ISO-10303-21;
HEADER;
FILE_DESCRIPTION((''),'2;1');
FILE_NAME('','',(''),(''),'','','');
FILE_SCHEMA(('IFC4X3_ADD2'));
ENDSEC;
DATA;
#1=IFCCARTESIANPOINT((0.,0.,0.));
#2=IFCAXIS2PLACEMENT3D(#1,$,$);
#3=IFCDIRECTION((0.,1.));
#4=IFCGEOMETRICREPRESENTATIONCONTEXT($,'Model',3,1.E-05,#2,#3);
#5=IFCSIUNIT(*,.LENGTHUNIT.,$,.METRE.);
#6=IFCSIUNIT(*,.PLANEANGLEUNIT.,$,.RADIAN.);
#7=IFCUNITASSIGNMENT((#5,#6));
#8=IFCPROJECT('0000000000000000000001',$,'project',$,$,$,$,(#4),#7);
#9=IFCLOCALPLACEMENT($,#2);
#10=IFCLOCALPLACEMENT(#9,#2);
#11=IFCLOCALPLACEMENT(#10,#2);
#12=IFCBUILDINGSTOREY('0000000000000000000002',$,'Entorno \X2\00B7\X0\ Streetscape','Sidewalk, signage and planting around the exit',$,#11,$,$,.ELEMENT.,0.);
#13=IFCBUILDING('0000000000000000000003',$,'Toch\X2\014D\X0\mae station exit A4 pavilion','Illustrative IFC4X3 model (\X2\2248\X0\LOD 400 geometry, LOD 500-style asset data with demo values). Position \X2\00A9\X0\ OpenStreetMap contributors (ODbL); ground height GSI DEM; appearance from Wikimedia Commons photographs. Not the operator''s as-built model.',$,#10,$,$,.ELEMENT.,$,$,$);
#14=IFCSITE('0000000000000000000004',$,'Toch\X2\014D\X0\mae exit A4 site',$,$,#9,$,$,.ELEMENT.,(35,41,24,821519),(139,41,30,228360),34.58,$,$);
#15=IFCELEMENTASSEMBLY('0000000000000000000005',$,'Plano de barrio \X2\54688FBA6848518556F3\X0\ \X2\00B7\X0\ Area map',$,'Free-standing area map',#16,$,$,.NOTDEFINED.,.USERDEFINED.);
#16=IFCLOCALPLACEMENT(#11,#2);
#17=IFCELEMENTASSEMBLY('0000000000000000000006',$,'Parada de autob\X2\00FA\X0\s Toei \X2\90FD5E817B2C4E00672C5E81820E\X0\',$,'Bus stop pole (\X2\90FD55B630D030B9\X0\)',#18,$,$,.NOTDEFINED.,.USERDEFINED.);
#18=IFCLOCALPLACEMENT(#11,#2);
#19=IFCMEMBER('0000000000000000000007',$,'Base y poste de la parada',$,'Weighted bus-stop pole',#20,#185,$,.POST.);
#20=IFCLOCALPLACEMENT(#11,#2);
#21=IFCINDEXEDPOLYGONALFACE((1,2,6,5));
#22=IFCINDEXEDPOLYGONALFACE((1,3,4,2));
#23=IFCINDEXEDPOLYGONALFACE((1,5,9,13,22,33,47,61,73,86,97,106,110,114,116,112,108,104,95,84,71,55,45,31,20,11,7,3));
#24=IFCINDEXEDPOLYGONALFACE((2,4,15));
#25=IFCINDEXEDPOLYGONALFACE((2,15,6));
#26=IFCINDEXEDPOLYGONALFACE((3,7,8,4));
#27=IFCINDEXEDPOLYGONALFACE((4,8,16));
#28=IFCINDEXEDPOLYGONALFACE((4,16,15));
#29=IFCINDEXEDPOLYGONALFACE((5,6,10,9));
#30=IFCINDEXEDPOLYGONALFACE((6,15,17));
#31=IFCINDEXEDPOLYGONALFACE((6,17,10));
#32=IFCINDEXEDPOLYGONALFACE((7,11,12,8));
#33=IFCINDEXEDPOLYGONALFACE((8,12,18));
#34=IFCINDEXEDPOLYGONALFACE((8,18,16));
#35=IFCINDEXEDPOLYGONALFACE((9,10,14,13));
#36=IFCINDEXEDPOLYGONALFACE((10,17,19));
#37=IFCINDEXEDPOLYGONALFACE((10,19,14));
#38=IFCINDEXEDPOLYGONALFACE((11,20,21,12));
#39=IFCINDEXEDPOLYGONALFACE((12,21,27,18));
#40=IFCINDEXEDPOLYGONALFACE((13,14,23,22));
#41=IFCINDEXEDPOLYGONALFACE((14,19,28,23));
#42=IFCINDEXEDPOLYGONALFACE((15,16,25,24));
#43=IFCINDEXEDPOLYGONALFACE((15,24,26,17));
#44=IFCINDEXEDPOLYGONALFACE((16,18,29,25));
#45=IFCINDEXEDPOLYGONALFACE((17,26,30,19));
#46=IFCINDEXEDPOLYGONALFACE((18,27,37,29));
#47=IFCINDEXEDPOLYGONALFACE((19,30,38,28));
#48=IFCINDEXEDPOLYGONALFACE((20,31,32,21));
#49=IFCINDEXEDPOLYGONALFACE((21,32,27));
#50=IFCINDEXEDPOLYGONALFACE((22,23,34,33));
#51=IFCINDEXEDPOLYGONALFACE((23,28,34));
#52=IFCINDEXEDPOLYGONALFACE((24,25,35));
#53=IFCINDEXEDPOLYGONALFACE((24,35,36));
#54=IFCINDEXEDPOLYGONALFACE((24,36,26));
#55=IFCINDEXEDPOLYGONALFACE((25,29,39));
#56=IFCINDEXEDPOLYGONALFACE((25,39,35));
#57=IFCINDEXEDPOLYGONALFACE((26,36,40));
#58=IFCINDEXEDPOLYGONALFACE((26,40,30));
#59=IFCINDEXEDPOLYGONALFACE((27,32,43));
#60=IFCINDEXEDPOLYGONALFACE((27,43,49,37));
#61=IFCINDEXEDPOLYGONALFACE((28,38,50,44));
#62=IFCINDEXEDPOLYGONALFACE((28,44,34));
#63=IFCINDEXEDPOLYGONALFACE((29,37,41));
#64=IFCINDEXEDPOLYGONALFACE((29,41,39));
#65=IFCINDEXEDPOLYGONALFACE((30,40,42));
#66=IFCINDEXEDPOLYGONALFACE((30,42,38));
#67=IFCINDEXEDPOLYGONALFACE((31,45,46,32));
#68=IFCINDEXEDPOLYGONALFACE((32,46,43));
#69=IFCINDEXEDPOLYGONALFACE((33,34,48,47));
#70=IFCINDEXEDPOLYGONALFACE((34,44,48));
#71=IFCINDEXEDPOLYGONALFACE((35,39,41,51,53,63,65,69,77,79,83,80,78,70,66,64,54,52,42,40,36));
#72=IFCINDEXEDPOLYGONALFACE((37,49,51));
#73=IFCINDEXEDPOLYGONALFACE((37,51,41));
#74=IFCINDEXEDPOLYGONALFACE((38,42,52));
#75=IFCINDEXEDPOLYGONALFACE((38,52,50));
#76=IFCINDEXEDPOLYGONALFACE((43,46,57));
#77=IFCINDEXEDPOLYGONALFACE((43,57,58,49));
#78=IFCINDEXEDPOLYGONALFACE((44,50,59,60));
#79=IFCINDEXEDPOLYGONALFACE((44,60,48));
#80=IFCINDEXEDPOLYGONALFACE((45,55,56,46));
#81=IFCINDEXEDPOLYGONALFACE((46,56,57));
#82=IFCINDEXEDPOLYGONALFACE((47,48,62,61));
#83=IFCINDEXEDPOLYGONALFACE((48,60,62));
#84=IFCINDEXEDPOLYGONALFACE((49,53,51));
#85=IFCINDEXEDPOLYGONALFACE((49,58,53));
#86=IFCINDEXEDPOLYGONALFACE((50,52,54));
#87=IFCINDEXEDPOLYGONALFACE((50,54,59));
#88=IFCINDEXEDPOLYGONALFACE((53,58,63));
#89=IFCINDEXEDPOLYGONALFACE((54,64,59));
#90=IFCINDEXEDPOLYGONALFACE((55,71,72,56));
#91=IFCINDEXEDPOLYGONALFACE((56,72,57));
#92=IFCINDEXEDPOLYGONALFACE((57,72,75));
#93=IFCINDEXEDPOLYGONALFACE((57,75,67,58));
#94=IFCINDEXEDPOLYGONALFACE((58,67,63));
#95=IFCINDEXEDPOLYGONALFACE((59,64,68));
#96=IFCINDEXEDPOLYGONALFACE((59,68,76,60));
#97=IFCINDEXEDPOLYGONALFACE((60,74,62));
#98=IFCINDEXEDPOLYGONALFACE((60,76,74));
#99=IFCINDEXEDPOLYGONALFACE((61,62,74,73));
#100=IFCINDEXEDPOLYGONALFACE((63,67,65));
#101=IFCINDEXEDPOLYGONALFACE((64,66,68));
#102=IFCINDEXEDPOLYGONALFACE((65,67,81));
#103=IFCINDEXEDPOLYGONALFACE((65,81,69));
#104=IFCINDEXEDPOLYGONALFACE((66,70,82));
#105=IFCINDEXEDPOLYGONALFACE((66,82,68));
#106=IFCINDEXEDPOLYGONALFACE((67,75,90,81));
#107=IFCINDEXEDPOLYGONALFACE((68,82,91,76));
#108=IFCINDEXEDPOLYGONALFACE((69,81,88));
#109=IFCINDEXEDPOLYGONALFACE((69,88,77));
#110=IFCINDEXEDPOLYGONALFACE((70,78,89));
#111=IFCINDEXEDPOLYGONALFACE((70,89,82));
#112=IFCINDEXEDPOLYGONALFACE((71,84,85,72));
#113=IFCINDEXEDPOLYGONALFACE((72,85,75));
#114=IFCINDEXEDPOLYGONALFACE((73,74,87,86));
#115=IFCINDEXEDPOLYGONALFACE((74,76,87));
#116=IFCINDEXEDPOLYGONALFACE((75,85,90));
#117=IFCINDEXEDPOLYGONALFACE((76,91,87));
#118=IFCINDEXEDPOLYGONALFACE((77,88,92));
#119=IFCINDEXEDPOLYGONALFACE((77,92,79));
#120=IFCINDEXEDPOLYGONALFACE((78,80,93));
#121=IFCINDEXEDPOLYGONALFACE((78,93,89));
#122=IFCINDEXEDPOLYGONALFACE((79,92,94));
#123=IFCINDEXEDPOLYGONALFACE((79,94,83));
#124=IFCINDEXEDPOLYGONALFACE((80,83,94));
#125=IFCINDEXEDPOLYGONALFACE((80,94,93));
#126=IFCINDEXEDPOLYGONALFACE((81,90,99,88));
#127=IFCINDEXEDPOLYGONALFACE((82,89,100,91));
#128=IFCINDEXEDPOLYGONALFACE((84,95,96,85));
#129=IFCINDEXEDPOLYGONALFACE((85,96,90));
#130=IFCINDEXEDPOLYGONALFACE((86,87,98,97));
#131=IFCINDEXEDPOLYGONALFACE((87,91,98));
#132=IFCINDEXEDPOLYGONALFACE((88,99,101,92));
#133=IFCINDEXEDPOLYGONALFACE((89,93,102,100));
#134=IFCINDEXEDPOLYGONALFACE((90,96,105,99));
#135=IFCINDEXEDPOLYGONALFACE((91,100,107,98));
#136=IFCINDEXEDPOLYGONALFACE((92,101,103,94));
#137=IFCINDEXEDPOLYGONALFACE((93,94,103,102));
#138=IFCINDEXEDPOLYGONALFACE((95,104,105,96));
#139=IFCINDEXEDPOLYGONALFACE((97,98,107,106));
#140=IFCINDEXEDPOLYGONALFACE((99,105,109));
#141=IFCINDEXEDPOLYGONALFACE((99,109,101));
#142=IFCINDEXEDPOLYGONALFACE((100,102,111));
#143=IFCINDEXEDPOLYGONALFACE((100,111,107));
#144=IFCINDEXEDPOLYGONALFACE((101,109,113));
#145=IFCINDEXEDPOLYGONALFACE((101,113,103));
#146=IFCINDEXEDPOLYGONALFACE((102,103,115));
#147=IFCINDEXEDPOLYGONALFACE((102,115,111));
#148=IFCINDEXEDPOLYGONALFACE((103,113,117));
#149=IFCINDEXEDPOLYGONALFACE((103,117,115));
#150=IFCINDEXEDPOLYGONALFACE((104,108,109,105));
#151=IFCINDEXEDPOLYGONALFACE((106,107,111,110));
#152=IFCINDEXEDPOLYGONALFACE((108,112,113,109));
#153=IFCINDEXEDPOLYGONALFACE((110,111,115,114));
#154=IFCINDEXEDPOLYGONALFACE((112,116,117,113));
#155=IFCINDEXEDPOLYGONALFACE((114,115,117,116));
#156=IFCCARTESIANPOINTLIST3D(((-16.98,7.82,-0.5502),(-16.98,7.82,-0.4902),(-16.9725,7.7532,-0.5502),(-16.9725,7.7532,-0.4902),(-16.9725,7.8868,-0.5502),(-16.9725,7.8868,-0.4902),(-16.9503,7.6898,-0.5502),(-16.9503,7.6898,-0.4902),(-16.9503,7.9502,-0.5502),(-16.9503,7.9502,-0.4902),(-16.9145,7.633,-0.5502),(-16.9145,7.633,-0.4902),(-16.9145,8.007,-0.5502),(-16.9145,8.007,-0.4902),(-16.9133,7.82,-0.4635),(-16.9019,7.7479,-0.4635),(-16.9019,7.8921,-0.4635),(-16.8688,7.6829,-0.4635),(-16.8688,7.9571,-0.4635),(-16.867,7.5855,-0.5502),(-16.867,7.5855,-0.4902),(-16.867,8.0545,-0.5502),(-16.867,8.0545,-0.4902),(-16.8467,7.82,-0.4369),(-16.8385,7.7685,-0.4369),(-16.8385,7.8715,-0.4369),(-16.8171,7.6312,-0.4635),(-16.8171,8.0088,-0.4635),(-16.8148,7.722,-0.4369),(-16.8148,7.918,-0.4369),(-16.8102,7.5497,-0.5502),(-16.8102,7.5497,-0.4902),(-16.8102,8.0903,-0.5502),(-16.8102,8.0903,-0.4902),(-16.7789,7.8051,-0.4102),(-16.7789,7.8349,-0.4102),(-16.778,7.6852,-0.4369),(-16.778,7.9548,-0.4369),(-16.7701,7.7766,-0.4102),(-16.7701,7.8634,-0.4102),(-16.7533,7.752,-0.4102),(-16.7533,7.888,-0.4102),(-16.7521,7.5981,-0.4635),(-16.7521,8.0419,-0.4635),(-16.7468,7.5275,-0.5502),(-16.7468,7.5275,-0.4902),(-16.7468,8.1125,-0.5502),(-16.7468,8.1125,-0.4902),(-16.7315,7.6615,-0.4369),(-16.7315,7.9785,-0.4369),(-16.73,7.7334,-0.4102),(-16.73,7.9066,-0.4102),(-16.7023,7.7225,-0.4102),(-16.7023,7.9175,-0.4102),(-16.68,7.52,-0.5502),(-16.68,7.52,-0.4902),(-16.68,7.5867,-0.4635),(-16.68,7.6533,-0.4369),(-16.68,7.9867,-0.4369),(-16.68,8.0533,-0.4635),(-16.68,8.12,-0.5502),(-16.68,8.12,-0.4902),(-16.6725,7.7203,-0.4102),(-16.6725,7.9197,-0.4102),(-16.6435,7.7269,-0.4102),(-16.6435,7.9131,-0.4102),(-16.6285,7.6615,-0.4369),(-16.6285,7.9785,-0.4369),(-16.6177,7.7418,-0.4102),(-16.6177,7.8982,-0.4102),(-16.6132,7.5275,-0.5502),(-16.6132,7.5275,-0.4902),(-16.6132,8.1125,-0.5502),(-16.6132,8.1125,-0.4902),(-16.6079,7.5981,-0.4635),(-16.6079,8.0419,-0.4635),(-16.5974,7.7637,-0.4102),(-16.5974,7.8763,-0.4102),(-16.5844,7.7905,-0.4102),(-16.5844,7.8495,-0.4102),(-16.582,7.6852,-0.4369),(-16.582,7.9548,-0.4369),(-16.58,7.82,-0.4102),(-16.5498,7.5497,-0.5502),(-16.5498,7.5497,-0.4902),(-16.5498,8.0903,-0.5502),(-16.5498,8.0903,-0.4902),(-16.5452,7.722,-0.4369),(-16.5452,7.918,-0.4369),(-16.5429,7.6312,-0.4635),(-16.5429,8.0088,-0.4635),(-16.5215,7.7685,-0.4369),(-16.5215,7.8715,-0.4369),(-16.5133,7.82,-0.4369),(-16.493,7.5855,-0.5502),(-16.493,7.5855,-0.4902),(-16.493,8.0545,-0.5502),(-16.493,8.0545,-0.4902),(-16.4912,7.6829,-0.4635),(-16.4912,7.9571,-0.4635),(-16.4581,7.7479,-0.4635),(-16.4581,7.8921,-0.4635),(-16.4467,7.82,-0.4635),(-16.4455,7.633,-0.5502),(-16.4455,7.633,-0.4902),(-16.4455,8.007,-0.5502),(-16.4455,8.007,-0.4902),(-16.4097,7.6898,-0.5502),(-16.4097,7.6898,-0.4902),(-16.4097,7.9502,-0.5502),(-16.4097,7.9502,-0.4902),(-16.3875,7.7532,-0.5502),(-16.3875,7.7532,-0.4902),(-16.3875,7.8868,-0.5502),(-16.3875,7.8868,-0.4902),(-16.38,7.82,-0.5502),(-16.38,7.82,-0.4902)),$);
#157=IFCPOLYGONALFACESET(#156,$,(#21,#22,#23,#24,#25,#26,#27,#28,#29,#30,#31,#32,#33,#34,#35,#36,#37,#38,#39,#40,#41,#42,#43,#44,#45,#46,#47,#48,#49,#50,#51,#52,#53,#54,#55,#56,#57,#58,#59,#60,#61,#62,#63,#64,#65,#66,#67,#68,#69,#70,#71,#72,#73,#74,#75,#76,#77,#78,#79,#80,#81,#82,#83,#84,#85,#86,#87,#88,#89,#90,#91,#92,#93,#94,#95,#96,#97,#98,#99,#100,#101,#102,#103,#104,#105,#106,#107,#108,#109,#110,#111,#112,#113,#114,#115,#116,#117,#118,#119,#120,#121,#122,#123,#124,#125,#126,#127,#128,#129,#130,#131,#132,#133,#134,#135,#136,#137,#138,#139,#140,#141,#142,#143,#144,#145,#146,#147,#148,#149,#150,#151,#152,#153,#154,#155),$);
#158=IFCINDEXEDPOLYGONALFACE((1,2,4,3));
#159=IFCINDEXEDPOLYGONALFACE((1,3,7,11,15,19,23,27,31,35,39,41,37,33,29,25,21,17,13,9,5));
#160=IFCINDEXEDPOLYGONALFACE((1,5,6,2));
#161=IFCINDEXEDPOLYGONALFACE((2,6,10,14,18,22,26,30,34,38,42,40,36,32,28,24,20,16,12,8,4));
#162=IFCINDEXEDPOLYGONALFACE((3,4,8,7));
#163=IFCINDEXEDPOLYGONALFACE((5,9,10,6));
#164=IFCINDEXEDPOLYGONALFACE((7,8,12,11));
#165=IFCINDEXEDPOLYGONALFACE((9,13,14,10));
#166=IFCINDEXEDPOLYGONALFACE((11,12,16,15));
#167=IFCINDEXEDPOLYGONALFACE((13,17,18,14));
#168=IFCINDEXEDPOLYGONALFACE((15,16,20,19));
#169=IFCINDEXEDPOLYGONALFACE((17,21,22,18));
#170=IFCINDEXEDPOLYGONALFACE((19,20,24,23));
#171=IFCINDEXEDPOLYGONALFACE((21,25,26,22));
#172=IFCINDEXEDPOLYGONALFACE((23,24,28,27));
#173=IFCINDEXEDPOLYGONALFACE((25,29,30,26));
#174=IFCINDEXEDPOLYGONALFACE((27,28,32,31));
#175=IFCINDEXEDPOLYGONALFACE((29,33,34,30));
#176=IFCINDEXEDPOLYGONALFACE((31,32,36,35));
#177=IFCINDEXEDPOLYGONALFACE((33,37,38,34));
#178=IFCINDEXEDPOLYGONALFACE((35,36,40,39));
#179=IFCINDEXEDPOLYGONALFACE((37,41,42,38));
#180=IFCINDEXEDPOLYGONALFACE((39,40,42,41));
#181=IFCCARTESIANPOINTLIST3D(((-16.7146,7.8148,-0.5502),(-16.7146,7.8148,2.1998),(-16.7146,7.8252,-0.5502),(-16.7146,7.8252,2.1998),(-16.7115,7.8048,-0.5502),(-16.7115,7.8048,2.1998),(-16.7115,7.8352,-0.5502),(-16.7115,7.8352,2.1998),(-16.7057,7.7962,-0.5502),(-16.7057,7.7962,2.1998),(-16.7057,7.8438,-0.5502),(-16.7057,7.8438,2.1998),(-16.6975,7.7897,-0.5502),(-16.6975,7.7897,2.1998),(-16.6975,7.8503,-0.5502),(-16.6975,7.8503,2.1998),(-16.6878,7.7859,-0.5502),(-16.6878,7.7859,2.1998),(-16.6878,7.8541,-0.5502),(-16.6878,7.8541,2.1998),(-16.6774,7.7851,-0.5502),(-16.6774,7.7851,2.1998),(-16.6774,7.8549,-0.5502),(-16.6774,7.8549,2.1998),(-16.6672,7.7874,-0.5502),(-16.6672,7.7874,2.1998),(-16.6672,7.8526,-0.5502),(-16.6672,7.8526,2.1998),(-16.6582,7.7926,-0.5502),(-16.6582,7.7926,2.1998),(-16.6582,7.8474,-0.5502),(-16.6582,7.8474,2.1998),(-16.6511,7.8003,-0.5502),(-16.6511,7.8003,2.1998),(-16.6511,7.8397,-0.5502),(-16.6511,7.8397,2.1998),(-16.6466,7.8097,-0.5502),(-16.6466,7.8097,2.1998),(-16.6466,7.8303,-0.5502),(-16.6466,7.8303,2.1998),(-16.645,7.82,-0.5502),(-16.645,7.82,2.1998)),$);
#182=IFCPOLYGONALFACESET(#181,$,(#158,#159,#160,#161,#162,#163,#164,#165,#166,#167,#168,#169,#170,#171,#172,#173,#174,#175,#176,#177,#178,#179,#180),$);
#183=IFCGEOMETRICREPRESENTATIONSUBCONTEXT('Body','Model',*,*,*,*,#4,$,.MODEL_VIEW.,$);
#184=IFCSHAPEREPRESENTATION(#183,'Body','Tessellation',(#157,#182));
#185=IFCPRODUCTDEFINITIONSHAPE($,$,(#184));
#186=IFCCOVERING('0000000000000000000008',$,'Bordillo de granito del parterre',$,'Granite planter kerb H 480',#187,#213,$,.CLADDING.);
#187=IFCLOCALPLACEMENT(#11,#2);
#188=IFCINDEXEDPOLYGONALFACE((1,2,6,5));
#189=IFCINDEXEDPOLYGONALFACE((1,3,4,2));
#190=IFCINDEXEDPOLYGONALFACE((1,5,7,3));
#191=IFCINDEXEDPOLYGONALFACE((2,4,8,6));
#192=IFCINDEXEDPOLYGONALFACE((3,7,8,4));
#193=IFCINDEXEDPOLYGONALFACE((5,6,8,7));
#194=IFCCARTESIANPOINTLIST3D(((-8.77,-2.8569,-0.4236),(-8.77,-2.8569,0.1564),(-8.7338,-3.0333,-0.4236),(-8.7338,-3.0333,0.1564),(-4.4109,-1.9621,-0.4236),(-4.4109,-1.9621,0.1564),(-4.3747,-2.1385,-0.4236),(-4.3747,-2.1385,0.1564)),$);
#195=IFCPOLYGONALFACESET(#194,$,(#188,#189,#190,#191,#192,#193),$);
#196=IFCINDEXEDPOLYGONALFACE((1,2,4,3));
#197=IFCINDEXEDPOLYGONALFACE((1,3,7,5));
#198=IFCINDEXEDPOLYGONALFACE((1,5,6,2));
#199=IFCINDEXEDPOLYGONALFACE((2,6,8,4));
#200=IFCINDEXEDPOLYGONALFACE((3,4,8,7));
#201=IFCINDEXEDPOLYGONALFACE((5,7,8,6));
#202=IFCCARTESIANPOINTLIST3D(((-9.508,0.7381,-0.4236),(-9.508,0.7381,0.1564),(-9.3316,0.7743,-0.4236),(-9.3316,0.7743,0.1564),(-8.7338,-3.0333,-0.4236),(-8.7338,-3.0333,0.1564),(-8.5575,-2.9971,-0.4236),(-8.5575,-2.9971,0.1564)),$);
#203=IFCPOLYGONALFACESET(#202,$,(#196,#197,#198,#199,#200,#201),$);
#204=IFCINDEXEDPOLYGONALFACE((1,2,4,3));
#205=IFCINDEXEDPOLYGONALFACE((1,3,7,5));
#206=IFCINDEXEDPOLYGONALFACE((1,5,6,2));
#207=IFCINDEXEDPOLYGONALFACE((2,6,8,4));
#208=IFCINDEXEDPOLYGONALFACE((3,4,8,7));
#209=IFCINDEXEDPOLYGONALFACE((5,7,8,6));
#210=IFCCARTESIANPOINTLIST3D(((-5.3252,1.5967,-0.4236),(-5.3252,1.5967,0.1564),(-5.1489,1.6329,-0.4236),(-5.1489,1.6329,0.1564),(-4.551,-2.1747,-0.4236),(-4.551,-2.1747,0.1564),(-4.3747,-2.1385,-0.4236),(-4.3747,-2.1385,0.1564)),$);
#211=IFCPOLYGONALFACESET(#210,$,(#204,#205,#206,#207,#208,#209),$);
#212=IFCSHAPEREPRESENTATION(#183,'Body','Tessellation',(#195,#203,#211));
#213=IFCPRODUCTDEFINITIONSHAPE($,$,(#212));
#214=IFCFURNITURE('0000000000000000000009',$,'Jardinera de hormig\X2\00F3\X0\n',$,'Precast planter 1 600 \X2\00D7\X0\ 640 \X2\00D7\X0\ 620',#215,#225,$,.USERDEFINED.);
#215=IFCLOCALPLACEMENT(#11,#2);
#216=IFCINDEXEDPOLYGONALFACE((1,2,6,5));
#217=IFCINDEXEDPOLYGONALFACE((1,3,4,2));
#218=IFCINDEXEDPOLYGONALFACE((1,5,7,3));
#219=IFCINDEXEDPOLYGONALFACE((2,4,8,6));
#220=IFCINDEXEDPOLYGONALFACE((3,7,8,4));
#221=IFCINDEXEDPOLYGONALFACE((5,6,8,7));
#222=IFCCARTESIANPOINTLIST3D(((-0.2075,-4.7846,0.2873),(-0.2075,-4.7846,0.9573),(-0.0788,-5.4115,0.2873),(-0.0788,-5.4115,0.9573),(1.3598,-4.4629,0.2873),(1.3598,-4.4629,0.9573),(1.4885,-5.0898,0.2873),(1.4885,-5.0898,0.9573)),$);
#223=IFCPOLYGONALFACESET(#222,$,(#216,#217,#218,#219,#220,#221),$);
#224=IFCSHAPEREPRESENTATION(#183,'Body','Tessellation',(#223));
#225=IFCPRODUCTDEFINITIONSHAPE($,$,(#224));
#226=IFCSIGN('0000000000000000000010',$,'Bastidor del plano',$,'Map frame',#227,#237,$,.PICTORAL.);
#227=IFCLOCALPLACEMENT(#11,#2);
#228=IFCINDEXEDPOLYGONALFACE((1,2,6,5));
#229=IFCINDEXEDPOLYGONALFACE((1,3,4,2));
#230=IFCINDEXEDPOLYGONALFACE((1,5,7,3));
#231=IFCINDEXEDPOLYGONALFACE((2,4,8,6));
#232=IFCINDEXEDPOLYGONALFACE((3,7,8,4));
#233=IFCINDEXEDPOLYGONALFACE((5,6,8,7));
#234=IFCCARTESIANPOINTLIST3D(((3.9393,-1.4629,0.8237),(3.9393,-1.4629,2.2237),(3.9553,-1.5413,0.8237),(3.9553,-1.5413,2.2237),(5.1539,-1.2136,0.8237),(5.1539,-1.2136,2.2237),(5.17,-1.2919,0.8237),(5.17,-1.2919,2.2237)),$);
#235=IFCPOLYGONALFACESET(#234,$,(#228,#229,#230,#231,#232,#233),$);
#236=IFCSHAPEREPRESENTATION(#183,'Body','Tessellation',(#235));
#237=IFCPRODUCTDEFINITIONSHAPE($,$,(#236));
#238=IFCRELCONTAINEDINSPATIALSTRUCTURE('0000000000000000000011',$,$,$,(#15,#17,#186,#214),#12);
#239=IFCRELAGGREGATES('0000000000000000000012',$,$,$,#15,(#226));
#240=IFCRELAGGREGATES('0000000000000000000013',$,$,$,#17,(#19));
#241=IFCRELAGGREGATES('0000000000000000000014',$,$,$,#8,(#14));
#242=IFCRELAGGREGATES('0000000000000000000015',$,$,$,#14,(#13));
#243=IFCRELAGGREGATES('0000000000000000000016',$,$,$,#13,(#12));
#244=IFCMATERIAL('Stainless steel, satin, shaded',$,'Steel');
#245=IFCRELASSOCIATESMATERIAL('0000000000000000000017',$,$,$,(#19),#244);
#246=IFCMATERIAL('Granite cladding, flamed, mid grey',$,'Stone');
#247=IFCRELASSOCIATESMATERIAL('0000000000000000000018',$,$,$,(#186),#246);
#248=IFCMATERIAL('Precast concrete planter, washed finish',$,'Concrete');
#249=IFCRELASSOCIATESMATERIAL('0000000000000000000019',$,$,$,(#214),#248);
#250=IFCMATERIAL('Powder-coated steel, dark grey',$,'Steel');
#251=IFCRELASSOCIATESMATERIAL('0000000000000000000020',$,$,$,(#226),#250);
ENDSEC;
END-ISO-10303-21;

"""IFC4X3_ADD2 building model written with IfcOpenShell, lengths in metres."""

from ifc_helpers import new_model, entity, si_unit, direction, frame, frame_2d, origin, origin_2d_with_axis, place, context, subcontext, project, spatial, rectangle, circle, extrude, material, element, aggregate, save


model = new_model("IFC4X3_ADD2")

# Units and contexts
model_context = context("Model", 3, precision=1e-05, world=origin(), true_north=direction((0.0, 1.0)))
body_context = subcontext(model_context, "Body", "Model", "MODEL_VIEW")
ifc_project = project(units=[si_unit("LENGTHUNIT", "METRE"), si_unit("PLANEANGLEUNIT", "RADIAN")], contexts=[model_context])

# Site, building, storey
site_placement = place(None, origin())
site = spatial("IfcSite", under=ifc_project, at=site_placement, Name="Tochōmae exit A4 site", CompositionType="ELEMENT", RefLatitude=(35, 41, 24, 821519), RefLongitude=(139, 41, 30, 228360), RefElevation=34.58)
building_placement = place(site_placement, origin())
building = spatial("IfcBuilding", under=site, at=building_placement, Name="Tochōmae station exit A4 pavilion", Description="Illustrative IFC4X3 model (≈LOD 400 geometry, LOD 500-style asset data with demo values). Position © OpenStreetMap contributors (ODbL); ground height GSI DEM; appearance from Wikimedia Commons photographs. Not the operator's as-built model.", CompositionType="ELEMENT")
storey_placement = place(building_placement, origin())
storey = spatial("IfcBuildingStorey", under=building, at=storey_placement, Name="Entorno · Streetscape", Description="Sidewalk, signage and planting around the exit", CompositionType="ELEMENT", Elevation=0.0)

# Element assemblies, member
assembly_1_placement = place(building_placement, origin())
assembly_1 = element("IfcElementAssembly", 1, at=assembly_1_placement, inside=storey, Name="Plano de barrio 周辺案内図 · Area map", ObjectType="Free-standing area map", AssemblyPlace="NOTDEFINED", PredefinedType="USERDEFINED")
ifc_material_1 = material(Name="Powder-coated steel, dark grey", Category="Steel")
assembly_2_placement = place(building_placement, origin())
assembly_2 = element("IfcElementAssembly", 2, at=assembly_2_placement, inside=storey, Name="Parada de autobús Toei 都庁第一本庁舎", ObjectType="Bus stop pole (都営バス)", AssemblyPlace="NOTDEFINED", PredefinedType="USERDEFINED")
ifc_material_2 = material(Name="Stainless steel, satin, shaded", Category="Steel")
member_1_placement = place(building_placement, origin())
member_1 = element("IfcMember", 3, at=member_1_placement, material=ifc_material_2, Name="Base y poste de la parada", ObjectType="Weighted bus-stop pole", PredefinedType="POST", context=body_context, shape_type="SweptSolid", body=[
    entity("IfcRevolvedAreaSolid", entity("IfcArbitraryClosedProfileDef", "AREA", None, entity("IfcPolyline", [entity("IfcCartesianPoint", [0.0, 0.0]), entity("IfcCartesianPoint", [0.3, 0.0]), entity("IfcCartesianPoint", [0.3, 0.06]), entity("IfcCartesianPoint", [0.1, 0.14]), entity("IfcCartesianPoint", [0.0, 0.14]), entity("IfcCartesianPoint", [0.0, 0.0])])), entity("IfcAxis2Placement3D", entity("IfcCartesianPoint", [-16.68, 7.82, -0.5502]), entity("IfcDirection", [0.0, -1.0, 0.0]), entity("IfcDirection", [1.0, 0.0, 0.0])), entity("IfcAxis1Placement", entity("IfcCartesianPoint", [0.0, 0.0, 0.0]), entity("IfcDirection", [0.0, 1.0, 0.0])), 6.283185),
    extrude(circle(Radius=0.035, at=origin_2d_with_axis()), frame((-16.68, 7.82, -0.5502)), (0.0, 0.0, 1.0), 2.75),
])

# Covering
ifc_material_3 = material(Name="Granite cladding, flamed, mid grey", Category="Stone")
covering_placement = place(building_placement, origin())
element("IfcCovering", 4, at=covering_placement, inside=storey, material=ifc_material_3, Name="Bordillo de granito del parterre", ObjectType="Granite planter kerb H 480", PredefinedType="CLADDING", context=body_context, shape_type="SweptSolid", body=[
    extrude(rectangle(XDim=4.45, YDim=0.18, at=frame_2d((0.0, 0.0), x_axis=(0.979575, 0.201078))), frame((-6.5724, -2.4977, -0.4236)), (0.0, 0.0, 1.0), 0.58),
    extrude(rectangle(XDim=0.18, YDim=3.85, at=frame_2d((0.0, 0.0), x_axis=(0.979575, 0.201078))), frame((-9.0327, -1.1295, -0.4236)), (0.0, 0.0, 1.0), 0.58),
    extrude(rectangle(XDim=0.18, YDim=3.85, at=frame_2d((0.0, 0.0), x_axis=(0.979575, 0.201078))), frame((-4.8499, -0.2709, -0.4236)), (0.0, 0.0, 1.0), 0.58),
])

# Furniture
ifc_material_4 = material(Name="Precast concrete planter, washed finish", Category="Concrete")
furniture_placement = place(building_placement, origin())
element("IfcFurniture", 5, at=furniture_placement, inside=storey, material=ifc_material_4, Name="Jardinera de hormigón", ObjectType="Precast planter 1 600 × 640 × 620", PredefinedType="USERDEFINED", context=body_context, shape_type="SweptSolid", body=[
    extrude(rectangle(XDim=1.6, YDim=0.64, at=frame_2d((0.0, 0.0), x_axis=(0.979575, 0.201078))), frame((0.6405, -4.9372, 0.2873)), (0.0, 0.0, 1.0), 0.67),
])

# Sign
sign_1_placement = place(building_placement, origin())
sign_1 = element("IfcSign", 6, at=sign_1_placement, material=ifc_material_1, Name="Bastidor del plano", ObjectType="Map frame", PredefinedType="PICTORAL", context=body_context, shape_type="SweptSolid", body=[
    extrude(rectangle(XDim=1.24, YDim=0.08, at=frame_2d((0.0, 0.0), x_axis=(0.979575, 0.201078))), frame((4.5546, -1.3774, 0.8237)), (0.0, 0.0, 1.0), 1.4),
])
aggregate(assembly_1, [sign_1])

aggregate(assembly_2, [member_1])

save(model, "model.ifc")
